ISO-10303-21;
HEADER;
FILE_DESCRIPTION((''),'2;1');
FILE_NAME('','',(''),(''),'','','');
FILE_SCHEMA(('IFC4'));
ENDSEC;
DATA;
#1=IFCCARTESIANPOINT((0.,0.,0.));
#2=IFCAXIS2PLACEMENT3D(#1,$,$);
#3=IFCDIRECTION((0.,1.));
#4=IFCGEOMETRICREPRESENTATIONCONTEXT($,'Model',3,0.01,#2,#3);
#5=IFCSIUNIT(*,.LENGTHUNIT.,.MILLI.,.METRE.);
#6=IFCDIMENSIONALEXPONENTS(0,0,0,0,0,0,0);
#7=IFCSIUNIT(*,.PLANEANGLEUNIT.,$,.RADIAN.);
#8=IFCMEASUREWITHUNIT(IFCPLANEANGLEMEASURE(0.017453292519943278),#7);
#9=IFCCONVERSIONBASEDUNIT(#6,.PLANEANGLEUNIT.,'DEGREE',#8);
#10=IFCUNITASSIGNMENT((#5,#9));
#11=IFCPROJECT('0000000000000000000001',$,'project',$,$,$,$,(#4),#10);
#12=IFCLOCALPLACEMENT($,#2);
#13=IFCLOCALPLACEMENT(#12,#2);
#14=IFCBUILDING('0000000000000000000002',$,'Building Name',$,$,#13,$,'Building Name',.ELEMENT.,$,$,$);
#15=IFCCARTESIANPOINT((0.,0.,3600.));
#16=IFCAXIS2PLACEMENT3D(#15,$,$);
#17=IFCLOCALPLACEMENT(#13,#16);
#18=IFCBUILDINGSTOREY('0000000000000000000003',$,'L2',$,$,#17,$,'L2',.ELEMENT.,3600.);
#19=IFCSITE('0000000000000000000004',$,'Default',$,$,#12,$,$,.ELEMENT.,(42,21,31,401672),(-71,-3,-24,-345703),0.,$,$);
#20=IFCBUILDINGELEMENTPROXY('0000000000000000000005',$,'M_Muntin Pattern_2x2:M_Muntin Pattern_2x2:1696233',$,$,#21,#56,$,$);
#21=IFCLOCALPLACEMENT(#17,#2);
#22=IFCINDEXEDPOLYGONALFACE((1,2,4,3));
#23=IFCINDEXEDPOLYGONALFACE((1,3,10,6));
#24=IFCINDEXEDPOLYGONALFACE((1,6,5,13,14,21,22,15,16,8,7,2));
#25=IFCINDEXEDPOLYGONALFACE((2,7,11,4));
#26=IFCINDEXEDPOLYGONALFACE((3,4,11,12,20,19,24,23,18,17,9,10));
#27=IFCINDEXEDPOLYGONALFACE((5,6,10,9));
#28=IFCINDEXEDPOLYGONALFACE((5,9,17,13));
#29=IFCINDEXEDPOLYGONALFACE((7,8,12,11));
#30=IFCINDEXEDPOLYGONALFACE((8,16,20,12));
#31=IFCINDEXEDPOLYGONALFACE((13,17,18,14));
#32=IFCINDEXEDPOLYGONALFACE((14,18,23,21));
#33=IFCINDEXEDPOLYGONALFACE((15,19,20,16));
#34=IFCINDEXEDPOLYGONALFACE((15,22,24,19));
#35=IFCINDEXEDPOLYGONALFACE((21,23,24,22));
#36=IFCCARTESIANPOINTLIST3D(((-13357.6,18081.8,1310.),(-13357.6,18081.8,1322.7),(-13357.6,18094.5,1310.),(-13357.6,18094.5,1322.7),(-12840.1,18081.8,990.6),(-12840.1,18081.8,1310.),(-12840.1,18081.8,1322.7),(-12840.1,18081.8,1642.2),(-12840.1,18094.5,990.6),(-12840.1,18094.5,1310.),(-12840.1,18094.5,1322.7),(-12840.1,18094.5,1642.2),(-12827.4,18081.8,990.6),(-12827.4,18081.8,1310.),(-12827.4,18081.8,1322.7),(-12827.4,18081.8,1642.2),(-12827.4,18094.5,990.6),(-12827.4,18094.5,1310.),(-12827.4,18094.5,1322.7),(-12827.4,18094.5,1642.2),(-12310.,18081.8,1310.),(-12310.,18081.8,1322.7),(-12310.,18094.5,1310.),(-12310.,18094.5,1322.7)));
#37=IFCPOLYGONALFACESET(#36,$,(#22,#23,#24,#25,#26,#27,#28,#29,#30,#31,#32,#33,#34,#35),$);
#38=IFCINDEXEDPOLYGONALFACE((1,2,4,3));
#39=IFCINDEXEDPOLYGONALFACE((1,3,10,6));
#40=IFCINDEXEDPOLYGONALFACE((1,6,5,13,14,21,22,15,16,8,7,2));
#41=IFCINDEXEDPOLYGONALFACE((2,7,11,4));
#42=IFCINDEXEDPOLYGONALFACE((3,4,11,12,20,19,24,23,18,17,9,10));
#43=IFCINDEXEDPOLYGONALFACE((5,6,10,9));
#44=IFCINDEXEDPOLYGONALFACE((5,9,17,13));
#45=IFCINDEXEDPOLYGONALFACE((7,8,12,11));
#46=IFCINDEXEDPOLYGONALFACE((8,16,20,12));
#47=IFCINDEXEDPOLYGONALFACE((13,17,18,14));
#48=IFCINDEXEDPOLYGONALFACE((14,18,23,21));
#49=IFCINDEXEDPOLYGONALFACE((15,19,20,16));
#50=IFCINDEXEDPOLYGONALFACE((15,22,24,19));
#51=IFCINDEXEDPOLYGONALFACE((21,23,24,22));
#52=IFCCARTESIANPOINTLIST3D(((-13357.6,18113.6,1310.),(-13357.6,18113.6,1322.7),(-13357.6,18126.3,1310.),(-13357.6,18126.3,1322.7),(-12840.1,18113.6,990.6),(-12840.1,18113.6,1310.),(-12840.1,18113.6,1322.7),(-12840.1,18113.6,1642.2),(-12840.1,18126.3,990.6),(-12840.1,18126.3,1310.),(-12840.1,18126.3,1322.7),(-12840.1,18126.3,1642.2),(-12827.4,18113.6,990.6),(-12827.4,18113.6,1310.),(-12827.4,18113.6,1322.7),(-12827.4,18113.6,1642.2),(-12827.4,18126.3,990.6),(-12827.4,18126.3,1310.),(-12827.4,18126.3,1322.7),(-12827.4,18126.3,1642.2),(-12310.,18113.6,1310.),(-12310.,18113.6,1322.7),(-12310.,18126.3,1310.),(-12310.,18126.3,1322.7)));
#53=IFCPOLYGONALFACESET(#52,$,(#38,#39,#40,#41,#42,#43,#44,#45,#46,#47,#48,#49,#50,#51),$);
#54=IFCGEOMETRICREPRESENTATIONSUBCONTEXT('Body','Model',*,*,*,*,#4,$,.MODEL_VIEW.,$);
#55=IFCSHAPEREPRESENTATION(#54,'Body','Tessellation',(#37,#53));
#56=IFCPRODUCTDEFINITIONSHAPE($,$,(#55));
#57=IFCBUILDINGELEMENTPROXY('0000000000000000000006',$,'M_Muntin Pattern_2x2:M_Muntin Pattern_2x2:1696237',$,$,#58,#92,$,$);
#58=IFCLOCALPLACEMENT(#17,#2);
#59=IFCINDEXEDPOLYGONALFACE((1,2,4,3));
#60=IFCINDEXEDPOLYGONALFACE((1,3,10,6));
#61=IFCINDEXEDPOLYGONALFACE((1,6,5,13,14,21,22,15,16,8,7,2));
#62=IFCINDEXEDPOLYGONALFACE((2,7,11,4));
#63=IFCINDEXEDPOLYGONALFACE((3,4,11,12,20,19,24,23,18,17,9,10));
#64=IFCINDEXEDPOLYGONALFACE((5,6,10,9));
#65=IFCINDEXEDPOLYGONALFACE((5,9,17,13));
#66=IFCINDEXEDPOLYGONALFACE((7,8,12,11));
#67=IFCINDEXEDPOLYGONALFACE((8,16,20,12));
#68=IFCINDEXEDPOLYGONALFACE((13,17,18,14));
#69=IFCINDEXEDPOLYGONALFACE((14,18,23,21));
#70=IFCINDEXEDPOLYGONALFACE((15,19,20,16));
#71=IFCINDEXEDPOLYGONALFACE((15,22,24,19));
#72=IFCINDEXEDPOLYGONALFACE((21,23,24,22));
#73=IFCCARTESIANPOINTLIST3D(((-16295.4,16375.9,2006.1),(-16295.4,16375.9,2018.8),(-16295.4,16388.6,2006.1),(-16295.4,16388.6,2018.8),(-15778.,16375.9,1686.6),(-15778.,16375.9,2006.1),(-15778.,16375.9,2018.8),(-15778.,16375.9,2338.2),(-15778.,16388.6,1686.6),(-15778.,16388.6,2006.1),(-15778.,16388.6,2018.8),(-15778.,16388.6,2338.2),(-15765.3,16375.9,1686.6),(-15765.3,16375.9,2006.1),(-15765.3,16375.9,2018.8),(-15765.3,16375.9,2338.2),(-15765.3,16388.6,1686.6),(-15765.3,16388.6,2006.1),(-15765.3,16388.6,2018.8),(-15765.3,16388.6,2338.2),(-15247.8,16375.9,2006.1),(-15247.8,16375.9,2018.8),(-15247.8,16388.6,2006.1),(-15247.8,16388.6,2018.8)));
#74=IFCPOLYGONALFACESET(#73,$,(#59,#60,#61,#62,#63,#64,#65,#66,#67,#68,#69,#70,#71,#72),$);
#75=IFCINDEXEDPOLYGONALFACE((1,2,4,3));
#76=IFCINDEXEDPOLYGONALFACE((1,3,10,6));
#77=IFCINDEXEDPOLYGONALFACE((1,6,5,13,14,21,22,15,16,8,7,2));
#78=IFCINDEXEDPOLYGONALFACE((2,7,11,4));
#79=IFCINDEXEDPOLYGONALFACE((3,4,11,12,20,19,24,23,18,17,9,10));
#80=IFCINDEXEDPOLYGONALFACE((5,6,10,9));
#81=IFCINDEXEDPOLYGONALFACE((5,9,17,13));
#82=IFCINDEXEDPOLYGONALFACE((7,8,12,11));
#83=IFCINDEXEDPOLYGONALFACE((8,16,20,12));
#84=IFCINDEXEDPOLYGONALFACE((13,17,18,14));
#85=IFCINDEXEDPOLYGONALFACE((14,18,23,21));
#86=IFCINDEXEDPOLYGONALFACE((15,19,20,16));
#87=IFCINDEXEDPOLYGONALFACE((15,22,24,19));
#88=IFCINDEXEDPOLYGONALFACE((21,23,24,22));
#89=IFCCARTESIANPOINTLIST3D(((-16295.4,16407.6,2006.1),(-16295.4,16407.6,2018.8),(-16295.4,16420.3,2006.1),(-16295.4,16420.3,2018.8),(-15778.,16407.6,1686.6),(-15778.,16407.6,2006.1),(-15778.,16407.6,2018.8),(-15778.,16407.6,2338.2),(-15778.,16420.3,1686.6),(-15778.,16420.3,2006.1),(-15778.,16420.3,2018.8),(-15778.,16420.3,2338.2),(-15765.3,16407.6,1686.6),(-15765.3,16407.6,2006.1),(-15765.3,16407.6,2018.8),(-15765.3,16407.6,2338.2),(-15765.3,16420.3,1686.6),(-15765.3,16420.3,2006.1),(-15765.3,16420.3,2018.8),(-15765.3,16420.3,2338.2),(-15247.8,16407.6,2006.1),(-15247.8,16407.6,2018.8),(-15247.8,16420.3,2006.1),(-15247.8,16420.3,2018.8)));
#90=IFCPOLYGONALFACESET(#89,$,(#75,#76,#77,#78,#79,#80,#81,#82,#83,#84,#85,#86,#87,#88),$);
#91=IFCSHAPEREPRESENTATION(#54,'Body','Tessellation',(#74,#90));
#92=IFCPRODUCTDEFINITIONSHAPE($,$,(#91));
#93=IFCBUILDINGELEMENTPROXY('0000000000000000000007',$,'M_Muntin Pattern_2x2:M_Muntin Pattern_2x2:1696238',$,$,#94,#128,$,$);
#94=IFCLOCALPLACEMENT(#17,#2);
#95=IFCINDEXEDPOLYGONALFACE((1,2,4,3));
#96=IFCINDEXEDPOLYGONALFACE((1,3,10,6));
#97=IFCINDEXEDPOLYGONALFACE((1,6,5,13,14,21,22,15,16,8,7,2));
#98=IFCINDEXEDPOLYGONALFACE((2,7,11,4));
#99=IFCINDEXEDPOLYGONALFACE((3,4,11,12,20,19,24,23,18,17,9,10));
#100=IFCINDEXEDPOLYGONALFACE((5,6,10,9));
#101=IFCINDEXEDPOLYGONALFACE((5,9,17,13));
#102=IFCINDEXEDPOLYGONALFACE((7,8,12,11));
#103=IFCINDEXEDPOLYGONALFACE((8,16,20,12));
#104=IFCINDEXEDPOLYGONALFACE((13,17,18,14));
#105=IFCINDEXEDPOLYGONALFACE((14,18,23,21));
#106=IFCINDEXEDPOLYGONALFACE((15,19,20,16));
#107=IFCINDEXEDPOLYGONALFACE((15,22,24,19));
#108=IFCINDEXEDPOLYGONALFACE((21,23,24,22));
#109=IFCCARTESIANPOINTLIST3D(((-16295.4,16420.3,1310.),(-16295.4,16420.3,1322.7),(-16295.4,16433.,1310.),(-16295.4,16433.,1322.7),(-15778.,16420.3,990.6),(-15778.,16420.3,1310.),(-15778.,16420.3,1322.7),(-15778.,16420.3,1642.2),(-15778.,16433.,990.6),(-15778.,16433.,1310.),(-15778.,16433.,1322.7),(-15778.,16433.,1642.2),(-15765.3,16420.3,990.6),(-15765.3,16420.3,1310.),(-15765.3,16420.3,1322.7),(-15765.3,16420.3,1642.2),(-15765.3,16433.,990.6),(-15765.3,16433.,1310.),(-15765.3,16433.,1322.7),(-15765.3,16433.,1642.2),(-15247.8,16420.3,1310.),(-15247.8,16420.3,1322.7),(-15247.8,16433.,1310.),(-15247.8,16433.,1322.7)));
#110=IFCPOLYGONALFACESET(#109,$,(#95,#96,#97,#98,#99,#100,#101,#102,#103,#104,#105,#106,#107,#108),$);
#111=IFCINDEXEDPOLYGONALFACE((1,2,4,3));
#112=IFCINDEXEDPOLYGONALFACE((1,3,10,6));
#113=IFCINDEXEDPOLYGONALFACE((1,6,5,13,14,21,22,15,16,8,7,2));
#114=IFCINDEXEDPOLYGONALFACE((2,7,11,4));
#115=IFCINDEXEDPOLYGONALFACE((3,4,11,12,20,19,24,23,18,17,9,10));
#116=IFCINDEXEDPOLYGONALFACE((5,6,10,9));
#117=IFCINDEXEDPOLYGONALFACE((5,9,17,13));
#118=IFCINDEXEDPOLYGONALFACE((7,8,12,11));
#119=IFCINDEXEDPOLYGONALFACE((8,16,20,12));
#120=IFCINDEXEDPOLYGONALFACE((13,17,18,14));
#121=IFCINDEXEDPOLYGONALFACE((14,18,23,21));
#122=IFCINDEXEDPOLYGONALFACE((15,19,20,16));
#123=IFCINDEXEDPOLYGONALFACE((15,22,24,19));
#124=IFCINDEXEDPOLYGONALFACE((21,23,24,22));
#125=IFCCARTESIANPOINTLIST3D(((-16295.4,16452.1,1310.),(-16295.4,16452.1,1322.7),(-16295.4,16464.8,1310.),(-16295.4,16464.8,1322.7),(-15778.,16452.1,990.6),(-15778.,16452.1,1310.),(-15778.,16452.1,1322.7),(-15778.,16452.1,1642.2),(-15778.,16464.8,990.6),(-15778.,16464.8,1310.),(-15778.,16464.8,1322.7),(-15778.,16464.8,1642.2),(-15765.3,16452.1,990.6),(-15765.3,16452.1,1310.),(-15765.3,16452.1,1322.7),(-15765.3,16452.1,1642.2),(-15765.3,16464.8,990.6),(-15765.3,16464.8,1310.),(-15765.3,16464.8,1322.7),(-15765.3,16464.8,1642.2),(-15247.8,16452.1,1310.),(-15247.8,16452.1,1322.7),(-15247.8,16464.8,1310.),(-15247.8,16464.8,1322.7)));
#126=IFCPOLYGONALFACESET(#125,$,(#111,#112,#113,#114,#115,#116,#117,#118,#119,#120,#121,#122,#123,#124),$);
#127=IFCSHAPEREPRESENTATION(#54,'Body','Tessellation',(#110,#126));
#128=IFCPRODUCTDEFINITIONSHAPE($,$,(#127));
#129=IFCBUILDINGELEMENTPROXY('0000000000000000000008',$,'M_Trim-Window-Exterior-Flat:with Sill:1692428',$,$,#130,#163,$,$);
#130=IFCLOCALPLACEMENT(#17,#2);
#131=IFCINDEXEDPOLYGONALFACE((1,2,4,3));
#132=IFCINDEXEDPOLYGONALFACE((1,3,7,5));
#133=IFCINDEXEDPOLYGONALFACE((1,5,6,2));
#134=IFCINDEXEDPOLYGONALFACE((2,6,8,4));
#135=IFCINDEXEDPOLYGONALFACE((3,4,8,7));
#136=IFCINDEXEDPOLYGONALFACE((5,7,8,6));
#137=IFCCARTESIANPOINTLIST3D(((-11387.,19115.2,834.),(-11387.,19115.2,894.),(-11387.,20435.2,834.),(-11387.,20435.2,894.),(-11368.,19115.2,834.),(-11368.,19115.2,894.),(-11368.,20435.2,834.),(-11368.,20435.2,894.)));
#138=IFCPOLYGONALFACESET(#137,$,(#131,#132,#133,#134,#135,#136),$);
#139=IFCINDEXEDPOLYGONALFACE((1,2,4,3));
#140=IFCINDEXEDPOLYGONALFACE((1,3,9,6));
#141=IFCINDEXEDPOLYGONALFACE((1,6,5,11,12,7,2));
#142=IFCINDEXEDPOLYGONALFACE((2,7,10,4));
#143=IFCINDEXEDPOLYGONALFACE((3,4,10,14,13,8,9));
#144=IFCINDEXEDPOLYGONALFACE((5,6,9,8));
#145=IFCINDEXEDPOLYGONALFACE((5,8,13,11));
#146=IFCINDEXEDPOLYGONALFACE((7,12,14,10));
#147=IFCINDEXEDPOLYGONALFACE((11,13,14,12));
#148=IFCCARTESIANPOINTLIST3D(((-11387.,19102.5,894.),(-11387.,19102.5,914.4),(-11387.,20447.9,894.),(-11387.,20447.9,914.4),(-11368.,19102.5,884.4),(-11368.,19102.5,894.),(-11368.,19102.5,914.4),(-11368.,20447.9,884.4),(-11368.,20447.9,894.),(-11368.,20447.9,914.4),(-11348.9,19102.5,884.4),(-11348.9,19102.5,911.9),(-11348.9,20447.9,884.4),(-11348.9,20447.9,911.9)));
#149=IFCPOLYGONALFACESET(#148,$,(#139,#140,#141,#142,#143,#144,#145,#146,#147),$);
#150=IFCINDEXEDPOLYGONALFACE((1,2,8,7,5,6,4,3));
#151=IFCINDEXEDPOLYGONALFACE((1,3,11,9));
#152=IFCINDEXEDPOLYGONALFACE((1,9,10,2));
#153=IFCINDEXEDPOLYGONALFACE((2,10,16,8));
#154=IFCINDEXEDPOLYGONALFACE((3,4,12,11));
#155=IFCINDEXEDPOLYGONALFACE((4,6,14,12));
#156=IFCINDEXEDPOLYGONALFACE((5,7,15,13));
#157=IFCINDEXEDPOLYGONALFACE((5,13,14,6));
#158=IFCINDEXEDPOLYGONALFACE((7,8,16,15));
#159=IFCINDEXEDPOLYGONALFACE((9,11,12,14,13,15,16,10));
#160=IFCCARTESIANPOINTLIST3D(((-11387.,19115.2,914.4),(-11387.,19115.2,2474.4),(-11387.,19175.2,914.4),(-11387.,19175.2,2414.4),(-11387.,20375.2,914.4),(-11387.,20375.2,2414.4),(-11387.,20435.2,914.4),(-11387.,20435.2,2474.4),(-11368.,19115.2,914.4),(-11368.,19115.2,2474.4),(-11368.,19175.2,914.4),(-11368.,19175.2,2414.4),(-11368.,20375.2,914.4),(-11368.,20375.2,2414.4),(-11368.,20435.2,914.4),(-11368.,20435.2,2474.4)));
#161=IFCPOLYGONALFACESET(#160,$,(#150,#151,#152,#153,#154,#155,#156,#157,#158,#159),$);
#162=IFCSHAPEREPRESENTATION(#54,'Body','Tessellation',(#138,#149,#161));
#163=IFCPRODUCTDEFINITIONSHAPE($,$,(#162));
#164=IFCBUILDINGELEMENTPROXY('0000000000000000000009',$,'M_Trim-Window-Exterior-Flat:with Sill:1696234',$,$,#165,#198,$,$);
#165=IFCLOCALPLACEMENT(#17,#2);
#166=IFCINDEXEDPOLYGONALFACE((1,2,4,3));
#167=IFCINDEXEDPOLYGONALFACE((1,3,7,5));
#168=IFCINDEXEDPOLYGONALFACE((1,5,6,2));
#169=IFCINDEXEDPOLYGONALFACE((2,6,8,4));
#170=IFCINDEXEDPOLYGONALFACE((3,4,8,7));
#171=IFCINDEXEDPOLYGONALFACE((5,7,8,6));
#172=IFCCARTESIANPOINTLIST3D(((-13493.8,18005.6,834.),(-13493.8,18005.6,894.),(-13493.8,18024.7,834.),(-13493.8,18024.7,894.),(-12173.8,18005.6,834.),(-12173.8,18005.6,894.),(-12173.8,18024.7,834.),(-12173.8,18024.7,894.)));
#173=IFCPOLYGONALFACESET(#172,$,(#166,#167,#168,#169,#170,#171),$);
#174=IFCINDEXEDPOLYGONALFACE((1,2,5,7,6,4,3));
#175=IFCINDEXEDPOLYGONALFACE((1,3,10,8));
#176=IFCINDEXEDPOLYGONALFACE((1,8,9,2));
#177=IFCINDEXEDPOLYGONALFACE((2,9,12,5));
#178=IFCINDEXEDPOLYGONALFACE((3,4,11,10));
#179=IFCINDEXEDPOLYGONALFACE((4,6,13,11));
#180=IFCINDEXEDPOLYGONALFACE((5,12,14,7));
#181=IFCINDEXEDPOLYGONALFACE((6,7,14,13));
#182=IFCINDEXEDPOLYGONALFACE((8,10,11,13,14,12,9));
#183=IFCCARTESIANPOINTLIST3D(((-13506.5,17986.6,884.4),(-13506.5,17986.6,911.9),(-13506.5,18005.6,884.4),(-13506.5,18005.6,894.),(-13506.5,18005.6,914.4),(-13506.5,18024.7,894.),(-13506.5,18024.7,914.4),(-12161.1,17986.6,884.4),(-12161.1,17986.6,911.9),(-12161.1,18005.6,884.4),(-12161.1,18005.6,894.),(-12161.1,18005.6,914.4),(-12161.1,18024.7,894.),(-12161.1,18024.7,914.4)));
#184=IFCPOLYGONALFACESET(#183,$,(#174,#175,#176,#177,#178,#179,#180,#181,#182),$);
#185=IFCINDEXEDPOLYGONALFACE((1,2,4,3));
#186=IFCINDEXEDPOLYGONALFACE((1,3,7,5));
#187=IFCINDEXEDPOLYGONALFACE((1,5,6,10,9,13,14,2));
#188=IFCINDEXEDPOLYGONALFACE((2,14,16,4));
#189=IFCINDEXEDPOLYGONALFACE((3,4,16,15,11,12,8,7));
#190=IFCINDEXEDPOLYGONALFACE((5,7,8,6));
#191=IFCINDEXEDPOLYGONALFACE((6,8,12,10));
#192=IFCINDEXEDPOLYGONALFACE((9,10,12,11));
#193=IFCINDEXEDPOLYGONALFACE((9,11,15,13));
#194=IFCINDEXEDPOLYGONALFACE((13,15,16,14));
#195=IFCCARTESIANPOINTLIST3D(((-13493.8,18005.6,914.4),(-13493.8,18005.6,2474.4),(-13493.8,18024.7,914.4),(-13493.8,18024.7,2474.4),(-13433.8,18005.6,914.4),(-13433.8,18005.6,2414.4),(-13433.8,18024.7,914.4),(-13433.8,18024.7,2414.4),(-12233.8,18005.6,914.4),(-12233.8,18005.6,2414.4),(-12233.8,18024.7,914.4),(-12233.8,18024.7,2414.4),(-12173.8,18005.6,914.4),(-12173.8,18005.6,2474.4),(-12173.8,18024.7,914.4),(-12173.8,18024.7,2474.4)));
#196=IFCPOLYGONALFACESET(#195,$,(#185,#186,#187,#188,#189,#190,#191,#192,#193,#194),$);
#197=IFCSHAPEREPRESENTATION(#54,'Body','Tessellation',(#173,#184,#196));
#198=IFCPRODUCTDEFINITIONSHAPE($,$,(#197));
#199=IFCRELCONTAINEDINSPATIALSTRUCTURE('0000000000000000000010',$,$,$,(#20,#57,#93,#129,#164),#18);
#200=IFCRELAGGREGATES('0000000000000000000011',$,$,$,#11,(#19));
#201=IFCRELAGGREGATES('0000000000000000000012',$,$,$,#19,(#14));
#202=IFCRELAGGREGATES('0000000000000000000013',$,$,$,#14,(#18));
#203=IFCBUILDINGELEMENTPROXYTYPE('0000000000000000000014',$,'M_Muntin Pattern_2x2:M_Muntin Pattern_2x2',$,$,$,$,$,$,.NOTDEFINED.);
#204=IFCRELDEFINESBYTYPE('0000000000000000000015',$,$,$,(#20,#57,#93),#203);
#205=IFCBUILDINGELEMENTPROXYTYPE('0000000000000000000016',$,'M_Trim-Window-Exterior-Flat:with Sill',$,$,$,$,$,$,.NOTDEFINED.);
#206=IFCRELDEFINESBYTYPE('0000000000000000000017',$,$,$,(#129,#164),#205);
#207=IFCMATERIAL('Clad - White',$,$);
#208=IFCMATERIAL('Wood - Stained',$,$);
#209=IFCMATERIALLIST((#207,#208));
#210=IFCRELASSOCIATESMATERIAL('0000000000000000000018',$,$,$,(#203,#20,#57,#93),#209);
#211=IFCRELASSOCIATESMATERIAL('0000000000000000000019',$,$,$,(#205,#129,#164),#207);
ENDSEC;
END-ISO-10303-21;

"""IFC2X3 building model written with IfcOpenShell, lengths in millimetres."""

from ifc_helpers import new_model, entity, si_unit, converted_unit, direction, frame, frame_2d, origin, place, context, subcontext, project, spatial, polyline, rectangle, outline, extrude, source, transform, mapped, material, material_list, type_object, type_shapes, element, save


model = new_model("IFC2X3")

# Units and contexts
model_context = context("Model", 3, precision=0.01, world=origin(), true_north=direction((0.0, 1.0)))
body_context = subcontext(model_context, "Body", "Model", "MODEL_VIEW")
ifc_project = project(units=[si_unit("LENGTHUNIT", "METRE", prefix="MILLI"), converted_unit("PLANEANGLEUNIT", "DEGREE", entity("IfcPlaneAngleMeasure", 0.017453292519943278), si_unit("PLANEANGLEUNIT", "RADIAN"), dimensions=[0, 0, 0, 0, 0, 0, 0])], contexts=[model_context])

# Site, building, storey
site_placement = place(None, origin())
site = spatial("IfcSite", under=ifc_project, at=site_placement, Name="Default", CompositionType="ELEMENT", RefLatitude=(42, 21, 31, 401672), RefLongitude=(-71, -3, -24, -345703), RefElevation=0.0)
building_placement = place(site_placement, origin())
building = spatial("IfcBuilding", under=site, at=building_placement, Name="Building Name", LongName="Building Name", CompositionType="ELEMENT")
storey_placement = place(building_placement, frame((0.0, 0.0, 3600.0)))
storey = spatial("IfcBuildingStorey", under=building, at=storey_placement, Name="L2", LongName="L2", CompositionType="ELEMENT", Elevation=3600.0)

# Shared definitions
ifc_material_1 = material(Name="Wood - Stained")

# Building element proxies
ifc_material_2 = material(Name="Clad - White")
ifc_material_list_1 = material_list([ifc_material_2, ifc_material_1])
building_element_proxy_type_1 = type_object("IfcBuildingElementProxyType", Name="M_Muntin Pattern_2x2:M_Muntin Pattern_2x2", PredefinedType="NOTDEFINED", material=ifc_material_list_1)
shared_shape_1 = source(origin(), body_context, "Body", "SweptSolid", [
    extrude(outline(polyline([(6.4, -6.4), (325.8, -6.4), (325.8, 6.3), (6.4, 6.3), (6.4, 523.8), (-6.3, 523.8), (-6.3, 6.3), (-325.8, 6.3), (-325.8, -6.4), (-6.3, -6.4), (-6.3, -523.8), (6.4, -523.8), (6.4, -6.4)])), frame((0.0, 9.5, 325.8), z_axis=(0.0, 1.0, 0.0), x_axis=(0.0, 0.0, 1.0)), (0.0, 0.0, 1.0), 12.7),
    extrude(outline(polyline([(6.4, -6.4), (325.8, -6.4), (325.8, 6.3), (6.4, 6.3), (6.4, 523.8), (-6.3, 523.8), (-6.3, 6.3), (-325.8, 6.3), (-325.8, -6.4), (-6.3, -6.4), (-6.3, -523.8), (6.4, -523.8), (6.4, -6.4)])), frame((0.0, -22.2, 325.8), z_axis=(0.0, 1.0, 0.0), x_axis=(0.0, 0.0, 1.0)), (0.0, 0.0, 1.0), 12.7),
])
type_shapes(building_element_proxy_type_1, [shared_shape_1])
for number, where, z_axis, x_axis, name in (
    (1, (-12833.8, 18104.0, 990.6), (0.0, 0.0, 1.0), (-1.0, 0.0, 0.0), "M_Muntin Pattern_2x2:M_Muntin Pattern_2x2:1696233"),
    (2, (-15771.6, 16398.1, 1686.6), (0.0, 0.0, 1.0), (-1.0, 0.0, 0.0), "M_Muntin Pattern_2x2:M_Muntin Pattern_2x2:1696237"),
    (3, (-15771.6, 16442.5, 990.6), (0.0, 0.0, 1.0), (-1.0, 0.0, 0.0), "M_Muntin Pattern_2x2:M_Muntin Pattern_2x2:1696238"),
):
    element("IfcBuildingElementProxy", number, at=place(storey_placement, frame(where, z_axis=z_axis, x_axis=x_axis)), inside=storey, type_object=building_element_proxy_type_1, material=ifc_material_list_1, Name=name, context=body_context, shape_type="MappedRepresentation", body=[
        mapped(shared_shape_1, transform((0.0, 0.0, 0.0), scale=1.0)),
    ])
building_element_proxy_type_2 = type_object("IfcBuildingElementProxyType", Name="M_Trim-Window-Exterior-Flat:with Sill", PredefinedType="NOTDEFINED", material=ifc_material_2)
shared_shape_2 = source(origin(), body_context, "Body", "SweptSolid", [
    extrude(rectangle(XDim=1320.0, YDim=60.0, at=frame_2d((0.0, 0.0), x_axis=(1.0, 0.0))), frame((0.0, -1550.4, 0.0), z_axis=(0.0, 0.0, 1.0), x_axis=(-1.0, 0.0, 0.0)), (0.0, 0.0, 1.0), 19.0),
    extrude(outline(polyline([(-19.0, -15.2), (0.0, -15.2), (0.0, -5.7), (19.0, -5.7), (19.0, 14.8), (0.0, 14.8), (-19.0, 12.3), (-19.0, -15.2)])), frame((-672.7, -1514.8, 19.0), z_axis=(1.0, 0.0, 0.0), x_axis=(0.0, 0.0, -1.0)), (0.0, 0.0, 1.0), 1345.4),
    extrude(outline(polyline([(-795.0, -660.0), (765.0, -660.0), (765.0, -600.0), (-735.0, -600.0), (-735.0, 600.0), (765.0, 600.0), (765.0, 660.0), (-795.0, 660.0), (-795.0, -660.0)])), frame((0.0, -735.0, 0.0), z_axis=(0.0, 0.0, 1.0), x_axis=(0.0, -1.0, 0.0)), (0.0, 0.0, 1.0), 19.0),
])
type_shapes(building_element_proxy_type_2, [shared_shape_2])
for number, where, z_axis, x_axis, name in (
    (4, (-11387.0, 19775.2, 2414.4), (1.0, 0.0, 0.0), (0.0, 1.0, 0.0), "M_Trim-Window-Exterior-Flat:with Sill:1692428"),
    (5, (-12833.8, 18024.7, 2414.4), (0.0, -1.0, 0.0), (1.0, 0.0, 0.0), "M_Trim-Window-Exterior-Flat:with Sill:1696234"),
):
    element("IfcBuildingElementProxy", number, at=place(storey_placement, frame(where, z_axis=z_axis, x_axis=x_axis)), inside=storey, type_object=building_element_proxy_type_2, material=ifc_material_2, Name=name, context=body_context, shape_type="MappedRepresentation", body=[
        mapped(shared_shape_2, transform((0.0, 0.0, 0.0), scale=1.0)),
    ])

save(model, "model.ifc")
